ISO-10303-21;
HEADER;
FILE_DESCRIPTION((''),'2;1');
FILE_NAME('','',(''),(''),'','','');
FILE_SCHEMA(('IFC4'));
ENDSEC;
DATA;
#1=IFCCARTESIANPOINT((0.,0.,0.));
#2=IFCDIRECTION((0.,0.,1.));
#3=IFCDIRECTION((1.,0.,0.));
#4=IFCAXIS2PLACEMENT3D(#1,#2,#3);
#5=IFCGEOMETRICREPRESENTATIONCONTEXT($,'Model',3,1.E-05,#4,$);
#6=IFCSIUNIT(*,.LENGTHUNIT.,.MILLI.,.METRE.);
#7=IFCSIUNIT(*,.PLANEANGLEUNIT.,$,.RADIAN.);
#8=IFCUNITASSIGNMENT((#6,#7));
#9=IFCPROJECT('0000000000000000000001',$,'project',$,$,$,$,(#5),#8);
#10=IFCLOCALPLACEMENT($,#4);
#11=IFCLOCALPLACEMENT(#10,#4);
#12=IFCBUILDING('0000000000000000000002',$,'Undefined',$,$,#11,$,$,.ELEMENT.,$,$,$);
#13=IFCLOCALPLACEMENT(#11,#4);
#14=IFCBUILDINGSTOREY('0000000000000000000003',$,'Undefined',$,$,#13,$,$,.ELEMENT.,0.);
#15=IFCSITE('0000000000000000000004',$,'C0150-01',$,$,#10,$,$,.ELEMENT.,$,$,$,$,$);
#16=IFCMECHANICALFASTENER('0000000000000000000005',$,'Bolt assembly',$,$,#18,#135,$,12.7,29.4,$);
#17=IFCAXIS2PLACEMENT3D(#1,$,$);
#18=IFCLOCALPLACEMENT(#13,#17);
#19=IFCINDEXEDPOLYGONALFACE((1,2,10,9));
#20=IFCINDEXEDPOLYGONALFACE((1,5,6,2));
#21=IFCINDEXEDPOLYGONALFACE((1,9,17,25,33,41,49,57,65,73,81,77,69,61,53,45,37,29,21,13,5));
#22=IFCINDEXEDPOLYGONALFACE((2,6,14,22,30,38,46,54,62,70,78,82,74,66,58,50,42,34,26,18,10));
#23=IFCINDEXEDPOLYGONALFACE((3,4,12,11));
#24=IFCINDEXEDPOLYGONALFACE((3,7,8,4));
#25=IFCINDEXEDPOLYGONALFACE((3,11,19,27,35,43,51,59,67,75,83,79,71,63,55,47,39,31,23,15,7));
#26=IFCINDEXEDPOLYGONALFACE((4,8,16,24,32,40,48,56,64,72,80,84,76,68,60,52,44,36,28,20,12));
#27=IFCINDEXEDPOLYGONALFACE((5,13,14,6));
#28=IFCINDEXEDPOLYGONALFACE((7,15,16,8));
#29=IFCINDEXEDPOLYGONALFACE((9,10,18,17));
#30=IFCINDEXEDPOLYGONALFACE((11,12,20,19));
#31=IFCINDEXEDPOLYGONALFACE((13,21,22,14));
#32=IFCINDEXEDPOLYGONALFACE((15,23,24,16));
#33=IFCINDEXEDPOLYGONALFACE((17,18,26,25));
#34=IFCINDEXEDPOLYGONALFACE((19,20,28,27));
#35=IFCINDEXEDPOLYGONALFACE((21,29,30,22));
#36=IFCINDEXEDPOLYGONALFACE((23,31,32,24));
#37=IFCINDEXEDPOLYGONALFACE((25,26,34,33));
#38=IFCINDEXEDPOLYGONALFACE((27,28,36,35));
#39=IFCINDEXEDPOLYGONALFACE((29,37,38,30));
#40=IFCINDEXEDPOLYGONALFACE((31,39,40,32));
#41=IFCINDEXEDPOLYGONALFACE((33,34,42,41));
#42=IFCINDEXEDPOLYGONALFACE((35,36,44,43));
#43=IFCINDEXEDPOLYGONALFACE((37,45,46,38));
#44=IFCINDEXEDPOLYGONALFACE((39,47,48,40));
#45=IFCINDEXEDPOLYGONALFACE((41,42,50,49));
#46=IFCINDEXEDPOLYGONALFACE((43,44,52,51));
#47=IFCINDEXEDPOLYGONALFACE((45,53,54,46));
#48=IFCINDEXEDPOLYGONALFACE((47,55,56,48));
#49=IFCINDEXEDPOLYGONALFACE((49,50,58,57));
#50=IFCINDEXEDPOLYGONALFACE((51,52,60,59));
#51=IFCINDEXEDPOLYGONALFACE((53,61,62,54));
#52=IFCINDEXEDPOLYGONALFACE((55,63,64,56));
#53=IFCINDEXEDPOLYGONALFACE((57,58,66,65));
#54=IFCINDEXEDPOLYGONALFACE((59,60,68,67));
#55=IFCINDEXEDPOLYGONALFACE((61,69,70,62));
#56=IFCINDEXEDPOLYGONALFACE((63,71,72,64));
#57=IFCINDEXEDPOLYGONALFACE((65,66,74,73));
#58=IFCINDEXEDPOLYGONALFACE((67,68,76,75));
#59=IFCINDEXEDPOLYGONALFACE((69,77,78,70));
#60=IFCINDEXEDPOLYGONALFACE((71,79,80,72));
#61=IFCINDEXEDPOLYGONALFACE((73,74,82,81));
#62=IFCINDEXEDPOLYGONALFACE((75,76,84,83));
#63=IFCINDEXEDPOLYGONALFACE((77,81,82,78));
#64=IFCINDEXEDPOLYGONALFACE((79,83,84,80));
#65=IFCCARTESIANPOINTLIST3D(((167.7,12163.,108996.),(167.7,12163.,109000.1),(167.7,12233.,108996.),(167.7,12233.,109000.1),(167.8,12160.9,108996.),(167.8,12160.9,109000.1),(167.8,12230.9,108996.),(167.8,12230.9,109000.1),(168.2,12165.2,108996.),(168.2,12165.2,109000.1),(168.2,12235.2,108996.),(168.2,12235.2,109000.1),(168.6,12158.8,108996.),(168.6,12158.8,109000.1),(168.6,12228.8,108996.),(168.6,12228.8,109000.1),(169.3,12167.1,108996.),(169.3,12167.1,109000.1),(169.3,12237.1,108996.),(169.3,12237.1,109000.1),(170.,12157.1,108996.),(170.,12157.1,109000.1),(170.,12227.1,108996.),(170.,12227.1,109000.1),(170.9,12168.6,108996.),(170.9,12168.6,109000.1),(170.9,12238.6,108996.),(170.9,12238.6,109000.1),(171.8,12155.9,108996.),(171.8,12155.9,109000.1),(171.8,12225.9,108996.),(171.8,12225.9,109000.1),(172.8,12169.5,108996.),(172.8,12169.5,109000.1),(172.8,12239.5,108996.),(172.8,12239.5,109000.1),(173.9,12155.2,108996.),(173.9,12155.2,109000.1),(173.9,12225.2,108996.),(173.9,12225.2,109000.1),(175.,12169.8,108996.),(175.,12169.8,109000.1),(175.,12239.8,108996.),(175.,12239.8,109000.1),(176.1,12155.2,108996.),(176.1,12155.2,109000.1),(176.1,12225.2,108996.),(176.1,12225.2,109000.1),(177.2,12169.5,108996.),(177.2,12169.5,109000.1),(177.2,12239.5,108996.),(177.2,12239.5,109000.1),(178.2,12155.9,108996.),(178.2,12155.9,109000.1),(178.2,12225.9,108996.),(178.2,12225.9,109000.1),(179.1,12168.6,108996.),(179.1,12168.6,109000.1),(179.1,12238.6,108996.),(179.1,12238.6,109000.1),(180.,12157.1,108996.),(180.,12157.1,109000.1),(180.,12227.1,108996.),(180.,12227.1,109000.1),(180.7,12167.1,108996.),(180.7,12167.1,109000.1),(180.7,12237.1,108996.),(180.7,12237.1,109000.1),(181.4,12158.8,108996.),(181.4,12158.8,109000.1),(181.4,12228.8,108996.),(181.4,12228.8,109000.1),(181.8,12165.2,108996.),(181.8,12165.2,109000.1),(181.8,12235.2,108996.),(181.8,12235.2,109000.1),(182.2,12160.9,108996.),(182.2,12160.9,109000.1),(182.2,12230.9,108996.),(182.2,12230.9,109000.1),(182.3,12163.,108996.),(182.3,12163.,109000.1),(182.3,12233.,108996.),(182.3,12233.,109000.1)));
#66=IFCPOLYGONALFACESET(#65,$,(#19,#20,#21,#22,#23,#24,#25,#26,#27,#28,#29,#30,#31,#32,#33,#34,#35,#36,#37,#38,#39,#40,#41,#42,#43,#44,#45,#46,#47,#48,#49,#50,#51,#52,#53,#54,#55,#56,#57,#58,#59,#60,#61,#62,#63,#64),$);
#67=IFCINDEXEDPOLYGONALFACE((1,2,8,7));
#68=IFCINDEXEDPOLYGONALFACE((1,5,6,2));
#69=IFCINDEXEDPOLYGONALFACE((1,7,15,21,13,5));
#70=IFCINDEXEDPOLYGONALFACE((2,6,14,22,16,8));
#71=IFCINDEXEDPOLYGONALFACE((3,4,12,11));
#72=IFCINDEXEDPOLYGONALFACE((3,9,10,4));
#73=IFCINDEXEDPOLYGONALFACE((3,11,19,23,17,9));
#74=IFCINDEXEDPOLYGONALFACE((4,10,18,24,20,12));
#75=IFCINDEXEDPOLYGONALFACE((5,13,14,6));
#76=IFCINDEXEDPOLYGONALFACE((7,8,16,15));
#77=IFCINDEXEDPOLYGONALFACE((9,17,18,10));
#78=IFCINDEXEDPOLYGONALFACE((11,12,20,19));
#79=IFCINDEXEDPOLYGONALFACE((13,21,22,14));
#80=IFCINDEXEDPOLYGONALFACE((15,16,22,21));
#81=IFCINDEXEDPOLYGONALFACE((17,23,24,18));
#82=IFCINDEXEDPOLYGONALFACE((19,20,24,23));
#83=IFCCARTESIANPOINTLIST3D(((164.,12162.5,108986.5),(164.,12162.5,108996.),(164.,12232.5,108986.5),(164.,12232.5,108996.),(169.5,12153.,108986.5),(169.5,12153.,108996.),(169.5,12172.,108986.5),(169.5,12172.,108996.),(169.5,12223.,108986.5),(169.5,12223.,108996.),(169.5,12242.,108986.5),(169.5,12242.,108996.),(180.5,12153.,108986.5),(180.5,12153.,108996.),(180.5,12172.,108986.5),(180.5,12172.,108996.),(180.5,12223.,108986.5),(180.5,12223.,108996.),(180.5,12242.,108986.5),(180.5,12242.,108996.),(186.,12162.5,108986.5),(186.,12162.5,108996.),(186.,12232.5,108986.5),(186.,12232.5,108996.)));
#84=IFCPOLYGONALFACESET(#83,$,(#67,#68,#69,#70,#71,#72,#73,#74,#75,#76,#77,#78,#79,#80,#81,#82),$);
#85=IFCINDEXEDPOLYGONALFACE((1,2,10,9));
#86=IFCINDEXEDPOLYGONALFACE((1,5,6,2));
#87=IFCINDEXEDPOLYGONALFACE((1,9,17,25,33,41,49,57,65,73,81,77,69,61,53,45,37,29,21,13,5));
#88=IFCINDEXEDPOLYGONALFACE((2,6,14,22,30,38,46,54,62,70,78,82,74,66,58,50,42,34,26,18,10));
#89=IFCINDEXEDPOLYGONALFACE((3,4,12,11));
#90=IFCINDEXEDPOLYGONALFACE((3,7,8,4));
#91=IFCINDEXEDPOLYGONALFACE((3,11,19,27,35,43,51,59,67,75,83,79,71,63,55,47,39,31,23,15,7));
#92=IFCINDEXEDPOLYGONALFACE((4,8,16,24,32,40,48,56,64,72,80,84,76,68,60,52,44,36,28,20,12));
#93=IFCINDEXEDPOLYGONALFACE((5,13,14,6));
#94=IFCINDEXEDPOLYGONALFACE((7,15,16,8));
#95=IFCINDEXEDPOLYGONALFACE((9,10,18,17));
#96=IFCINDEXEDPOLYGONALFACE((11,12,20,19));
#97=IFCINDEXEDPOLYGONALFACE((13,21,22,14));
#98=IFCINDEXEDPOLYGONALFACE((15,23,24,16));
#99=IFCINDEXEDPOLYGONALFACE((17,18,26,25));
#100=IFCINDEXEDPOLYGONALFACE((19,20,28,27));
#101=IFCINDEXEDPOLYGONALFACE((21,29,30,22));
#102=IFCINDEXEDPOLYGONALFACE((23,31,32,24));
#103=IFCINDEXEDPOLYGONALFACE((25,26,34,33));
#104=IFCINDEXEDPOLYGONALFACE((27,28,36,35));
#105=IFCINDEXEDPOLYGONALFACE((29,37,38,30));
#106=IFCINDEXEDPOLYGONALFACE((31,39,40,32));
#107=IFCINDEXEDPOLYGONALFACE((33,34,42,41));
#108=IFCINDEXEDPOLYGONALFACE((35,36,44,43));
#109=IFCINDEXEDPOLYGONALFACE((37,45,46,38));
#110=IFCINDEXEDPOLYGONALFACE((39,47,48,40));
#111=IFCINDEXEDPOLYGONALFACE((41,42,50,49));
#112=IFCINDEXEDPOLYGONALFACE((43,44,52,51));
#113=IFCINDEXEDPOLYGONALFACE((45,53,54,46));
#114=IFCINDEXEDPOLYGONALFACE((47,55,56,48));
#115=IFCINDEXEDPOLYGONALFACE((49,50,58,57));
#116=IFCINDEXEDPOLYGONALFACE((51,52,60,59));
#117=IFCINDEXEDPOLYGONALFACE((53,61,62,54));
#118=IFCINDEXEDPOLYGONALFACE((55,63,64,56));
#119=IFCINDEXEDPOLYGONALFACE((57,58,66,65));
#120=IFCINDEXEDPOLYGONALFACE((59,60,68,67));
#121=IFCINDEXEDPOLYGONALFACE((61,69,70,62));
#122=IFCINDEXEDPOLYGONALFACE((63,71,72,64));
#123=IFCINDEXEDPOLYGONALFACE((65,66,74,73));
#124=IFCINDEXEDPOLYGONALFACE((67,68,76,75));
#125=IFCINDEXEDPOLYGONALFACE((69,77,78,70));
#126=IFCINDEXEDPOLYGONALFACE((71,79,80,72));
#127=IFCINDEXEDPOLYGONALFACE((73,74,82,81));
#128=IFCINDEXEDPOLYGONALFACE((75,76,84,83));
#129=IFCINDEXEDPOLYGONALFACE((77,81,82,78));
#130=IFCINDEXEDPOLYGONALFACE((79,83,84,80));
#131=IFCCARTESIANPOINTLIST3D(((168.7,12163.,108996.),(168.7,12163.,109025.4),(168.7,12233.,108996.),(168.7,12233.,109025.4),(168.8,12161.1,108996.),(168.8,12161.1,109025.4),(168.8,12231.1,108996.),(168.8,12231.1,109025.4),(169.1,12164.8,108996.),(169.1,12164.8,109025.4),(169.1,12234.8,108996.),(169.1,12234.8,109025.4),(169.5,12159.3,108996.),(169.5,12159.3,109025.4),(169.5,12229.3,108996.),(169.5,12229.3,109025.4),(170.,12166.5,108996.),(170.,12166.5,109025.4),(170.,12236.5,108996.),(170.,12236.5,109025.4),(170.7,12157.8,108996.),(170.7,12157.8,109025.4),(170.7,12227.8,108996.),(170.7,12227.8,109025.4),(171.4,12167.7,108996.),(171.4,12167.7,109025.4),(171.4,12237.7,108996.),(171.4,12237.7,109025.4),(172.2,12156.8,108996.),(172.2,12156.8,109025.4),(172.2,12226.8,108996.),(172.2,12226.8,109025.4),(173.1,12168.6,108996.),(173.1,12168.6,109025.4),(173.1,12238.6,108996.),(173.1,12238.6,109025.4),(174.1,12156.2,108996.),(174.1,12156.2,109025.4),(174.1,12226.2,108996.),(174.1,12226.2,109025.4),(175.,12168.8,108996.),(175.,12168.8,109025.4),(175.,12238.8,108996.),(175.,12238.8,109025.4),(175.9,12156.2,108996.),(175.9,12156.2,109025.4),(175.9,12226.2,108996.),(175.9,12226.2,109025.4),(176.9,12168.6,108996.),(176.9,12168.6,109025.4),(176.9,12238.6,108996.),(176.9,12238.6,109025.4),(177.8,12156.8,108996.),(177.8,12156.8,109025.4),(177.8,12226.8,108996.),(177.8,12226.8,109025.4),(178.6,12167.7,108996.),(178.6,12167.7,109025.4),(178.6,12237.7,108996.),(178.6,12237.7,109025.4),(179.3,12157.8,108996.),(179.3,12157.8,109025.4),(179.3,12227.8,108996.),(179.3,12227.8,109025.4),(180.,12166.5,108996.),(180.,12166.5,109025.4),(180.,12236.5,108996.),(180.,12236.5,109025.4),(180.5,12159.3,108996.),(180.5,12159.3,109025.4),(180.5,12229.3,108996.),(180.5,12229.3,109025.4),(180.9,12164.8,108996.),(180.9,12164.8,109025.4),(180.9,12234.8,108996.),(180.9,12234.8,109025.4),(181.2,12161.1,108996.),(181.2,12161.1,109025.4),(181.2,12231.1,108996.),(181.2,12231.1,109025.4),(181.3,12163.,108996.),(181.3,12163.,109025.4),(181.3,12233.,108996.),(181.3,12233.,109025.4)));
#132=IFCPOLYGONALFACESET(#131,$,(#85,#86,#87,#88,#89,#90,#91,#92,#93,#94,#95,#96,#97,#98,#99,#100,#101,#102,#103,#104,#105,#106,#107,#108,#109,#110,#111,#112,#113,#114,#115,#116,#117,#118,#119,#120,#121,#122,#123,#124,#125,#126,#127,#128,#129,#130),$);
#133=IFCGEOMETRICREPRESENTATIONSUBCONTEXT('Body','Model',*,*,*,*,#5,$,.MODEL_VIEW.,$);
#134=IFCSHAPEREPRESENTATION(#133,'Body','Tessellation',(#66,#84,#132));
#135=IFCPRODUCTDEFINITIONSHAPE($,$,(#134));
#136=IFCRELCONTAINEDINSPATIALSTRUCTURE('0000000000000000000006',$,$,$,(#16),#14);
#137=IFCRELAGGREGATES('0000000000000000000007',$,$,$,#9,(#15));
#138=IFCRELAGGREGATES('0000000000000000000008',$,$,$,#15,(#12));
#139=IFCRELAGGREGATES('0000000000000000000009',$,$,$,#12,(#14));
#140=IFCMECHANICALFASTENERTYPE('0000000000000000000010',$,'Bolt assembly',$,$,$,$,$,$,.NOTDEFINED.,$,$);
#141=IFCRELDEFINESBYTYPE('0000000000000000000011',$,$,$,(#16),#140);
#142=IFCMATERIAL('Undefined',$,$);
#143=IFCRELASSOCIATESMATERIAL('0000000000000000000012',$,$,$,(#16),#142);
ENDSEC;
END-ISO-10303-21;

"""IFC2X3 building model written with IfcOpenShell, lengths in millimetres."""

from ifc_helpers import new_model, si_unit, frame, origin_with_axes, origin_2d_with_axis, place, context, subcontext, project, spatial, polyline, circle, outline, extrude, source, transform, mapped, material, type_object, element, save


model = new_model("IFC2X3")

# Units and contexts
model_context = context("Model", 3, precision=1e-05, world=origin_with_axes())
body_context = subcontext(model_context, "Body", "Model", "MODEL_VIEW")
ifc_project = project(units=[si_unit("LENGTHUNIT", "METRE", prefix="MILLI"), si_unit("PLANEANGLEUNIT", "RADIAN")], contexts=[model_context])

# Site, building, storey
site_placement = place(None, origin_with_axes())
site = spatial("IfcSite", under=ifc_project, at=site_placement, Name="C0150-01", CompositionType="ELEMENT")
building_placement = place(site_placement, origin_with_axes())
building = spatial("IfcBuilding", under=site, at=building_placement, Name="Undefined", CompositionType="ELEMENT")
storey_placement = place(building_placement, origin_with_axes())
storey = spatial("IfcBuildingStorey", under=building, at=storey_placement, Name="Undefined", CompositionType="ELEMENT", Elevation=0.0)

# Mechanical fastener
ifc_material_1 = material(Name="Undefined")
mechanical_fastener_type = type_object("IfcMechanicalFastenerType", Name="Bolt assembly")
shared_shape_1 = source(origin_with_axes(), body_context, "Body", "SweptSolid", [
    extrude(circle(Radius=7.3, at=origin_2d_with_axis()), frame((0.0, 0.0, 0.0), z_axis=(0.0, 1.0, 0.0), x_axis=(1.0, 0.0, 0.0)), (0.0, 0.0, 1.0), 4.1),
    extrude(outline(polyline([(9.5, -5.5), (9.5, 5.5), (0.0, 11.0), (-9.5, 5.5), (-9.5, -5.5), (0.0, -11.0), (9.5, -5.5)])), frame((0.0, -9.5, 0.0), z_axis=(0.0, 1.0, 0.0), x_axis=(1.0, 0.0, 0.0)), (0.0, 0.0, 1.0), 9.5),
    extrude(circle(Radius=6.3, at=origin_2d_with_axis()), frame((0.0, 0.0, 0.0), z_axis=(0.0, 1.0, 0.0), x_axis=(1.0, 0.0, 0.0)), (0.0, 0.0, 1.0), 29.4),
])
mechanical_fastener_1_placement = place(storey_placement, frame((175.0, 12162.5, 108996.0), z_axis=(1.0, 0.0, 0.0), x_axis=(0.0, 1.0, 0.0)))
element("IfcMechanicalFastener", 1, at=mechanical_fastener_1_placement, inside=storey, type_object=mechanical_fastener_type, material=ifc_material_1, Name="Bolt assembly", NominalDiameter=12.7, NominalLength=29.4, context=body_context, shape_type="MappedRepresentation", body=[
    mapped(shared_shape_1, transform((0.0, 0.0, 0.0))),
    mapped(shared_shape_1, transform((70.0, 0.0, 0.0))),
])

save(model, "model.ifc")
